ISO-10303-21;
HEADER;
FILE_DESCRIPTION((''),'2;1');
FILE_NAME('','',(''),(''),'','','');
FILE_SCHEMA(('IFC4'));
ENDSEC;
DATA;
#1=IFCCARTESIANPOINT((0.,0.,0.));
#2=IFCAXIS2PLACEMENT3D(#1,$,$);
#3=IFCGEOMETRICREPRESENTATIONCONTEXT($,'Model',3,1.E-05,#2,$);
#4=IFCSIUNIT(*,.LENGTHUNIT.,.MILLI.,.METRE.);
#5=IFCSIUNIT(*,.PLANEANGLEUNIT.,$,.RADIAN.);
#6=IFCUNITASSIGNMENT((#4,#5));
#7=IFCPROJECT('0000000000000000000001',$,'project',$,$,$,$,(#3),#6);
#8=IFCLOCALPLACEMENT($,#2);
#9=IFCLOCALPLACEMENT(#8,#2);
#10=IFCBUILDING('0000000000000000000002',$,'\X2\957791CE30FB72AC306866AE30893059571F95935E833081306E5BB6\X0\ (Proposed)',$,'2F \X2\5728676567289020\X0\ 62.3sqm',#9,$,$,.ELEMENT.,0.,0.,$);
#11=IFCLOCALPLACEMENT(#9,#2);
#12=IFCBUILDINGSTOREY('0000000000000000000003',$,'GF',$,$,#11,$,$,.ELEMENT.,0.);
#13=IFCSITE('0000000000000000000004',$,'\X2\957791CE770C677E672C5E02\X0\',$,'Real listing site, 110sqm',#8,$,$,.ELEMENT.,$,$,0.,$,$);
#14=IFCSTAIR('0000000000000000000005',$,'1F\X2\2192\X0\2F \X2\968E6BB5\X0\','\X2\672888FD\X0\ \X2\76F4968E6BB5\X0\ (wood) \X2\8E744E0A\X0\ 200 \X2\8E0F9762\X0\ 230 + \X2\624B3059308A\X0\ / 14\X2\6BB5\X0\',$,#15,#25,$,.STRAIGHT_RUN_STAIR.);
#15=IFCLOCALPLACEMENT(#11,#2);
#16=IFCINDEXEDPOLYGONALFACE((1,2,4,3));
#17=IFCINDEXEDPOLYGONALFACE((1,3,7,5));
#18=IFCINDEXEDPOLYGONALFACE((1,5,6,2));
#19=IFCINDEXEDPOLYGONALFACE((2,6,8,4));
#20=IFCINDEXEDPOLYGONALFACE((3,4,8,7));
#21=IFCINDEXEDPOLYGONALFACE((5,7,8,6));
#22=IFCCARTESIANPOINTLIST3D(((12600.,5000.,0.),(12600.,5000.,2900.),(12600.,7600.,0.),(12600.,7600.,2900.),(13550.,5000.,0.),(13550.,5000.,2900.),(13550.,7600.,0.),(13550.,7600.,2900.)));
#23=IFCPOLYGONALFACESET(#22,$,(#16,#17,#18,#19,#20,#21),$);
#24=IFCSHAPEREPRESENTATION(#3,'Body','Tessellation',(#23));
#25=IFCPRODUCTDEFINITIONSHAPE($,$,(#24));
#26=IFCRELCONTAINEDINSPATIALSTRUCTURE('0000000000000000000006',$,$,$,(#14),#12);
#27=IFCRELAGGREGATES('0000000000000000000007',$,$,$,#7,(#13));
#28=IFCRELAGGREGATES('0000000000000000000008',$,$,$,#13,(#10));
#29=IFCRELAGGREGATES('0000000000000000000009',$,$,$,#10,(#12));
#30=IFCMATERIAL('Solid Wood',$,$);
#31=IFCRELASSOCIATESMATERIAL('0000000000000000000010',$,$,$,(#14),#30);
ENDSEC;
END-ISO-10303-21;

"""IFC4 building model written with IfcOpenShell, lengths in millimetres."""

from ifc_helpers import new_model, si_unit, frame, frame_2d, origin, place, context, project, spatial, rectangle, extrude, material, element, save


model = new_model("IFC4")

# Units and contexts
model_context = context("Model", 3, precision=1e-05, world=origin())
ifc_project = project(units=[si_unit("LENGTHUNIT", "METRE", prefix="MILLI"), si_unit("PLANEANGLEUNIT", "RADIAN")], contexts=[model_context])

# Site, building, storey
site_placement = place(None, origin())
site = spatial("IfcSite", under=ifc_project, at=site_placement, Name="長野県松本市", ObjectType="Real listing site, 110sqm", CompositionType="ELEMENT", RefElevation=0.0)
building_placement = place(site_placement, origin())
building = spatial("IfcBuilding", under=site, at=building_placement, Name="長野・犬と暮らす土間広めの家 (Proposed)", ObjectType="2F 在来木造 62.3sqm", CompositionType="ELEMENT", ElevationOfRefHeight=0.0, ElevationOfTerrain=0.0)
storey_placement = place(building_placement, origin())
storey = spatial("IfcBuildingStorey", under=building, at=storey_placement, Name="GF", CompositionType="ELEMENT", Elevation=0.0)

# Shared definitions
ifc_material_1 = material(Name="Solid Wood")

# Stair
stair_placement = place(storey_placement, frame((6300.0, 2500.0, 0.0)))
element("IfcStair", 1, at=stair_placement, inside=storey, material=ifc_material_1, Name="1F→2F 階段", Description="木製 直階段 (wood) 蹴上 200 踏面 230 + 手すり / 14段", PredefinedType="STRAIGHT_RUN_STAIR", context=model_context, shape_type="SweptSolid", body=[
    extrude(rectangle(XDim=950.0, YDim=2600.0, at=frame_2d((475.0, 1300.0))), frame((6300.0, 2500.0, 0.0)), (0.0, 0.0, 1.0), 2900.0),
])

save(model, "model.ifc")
